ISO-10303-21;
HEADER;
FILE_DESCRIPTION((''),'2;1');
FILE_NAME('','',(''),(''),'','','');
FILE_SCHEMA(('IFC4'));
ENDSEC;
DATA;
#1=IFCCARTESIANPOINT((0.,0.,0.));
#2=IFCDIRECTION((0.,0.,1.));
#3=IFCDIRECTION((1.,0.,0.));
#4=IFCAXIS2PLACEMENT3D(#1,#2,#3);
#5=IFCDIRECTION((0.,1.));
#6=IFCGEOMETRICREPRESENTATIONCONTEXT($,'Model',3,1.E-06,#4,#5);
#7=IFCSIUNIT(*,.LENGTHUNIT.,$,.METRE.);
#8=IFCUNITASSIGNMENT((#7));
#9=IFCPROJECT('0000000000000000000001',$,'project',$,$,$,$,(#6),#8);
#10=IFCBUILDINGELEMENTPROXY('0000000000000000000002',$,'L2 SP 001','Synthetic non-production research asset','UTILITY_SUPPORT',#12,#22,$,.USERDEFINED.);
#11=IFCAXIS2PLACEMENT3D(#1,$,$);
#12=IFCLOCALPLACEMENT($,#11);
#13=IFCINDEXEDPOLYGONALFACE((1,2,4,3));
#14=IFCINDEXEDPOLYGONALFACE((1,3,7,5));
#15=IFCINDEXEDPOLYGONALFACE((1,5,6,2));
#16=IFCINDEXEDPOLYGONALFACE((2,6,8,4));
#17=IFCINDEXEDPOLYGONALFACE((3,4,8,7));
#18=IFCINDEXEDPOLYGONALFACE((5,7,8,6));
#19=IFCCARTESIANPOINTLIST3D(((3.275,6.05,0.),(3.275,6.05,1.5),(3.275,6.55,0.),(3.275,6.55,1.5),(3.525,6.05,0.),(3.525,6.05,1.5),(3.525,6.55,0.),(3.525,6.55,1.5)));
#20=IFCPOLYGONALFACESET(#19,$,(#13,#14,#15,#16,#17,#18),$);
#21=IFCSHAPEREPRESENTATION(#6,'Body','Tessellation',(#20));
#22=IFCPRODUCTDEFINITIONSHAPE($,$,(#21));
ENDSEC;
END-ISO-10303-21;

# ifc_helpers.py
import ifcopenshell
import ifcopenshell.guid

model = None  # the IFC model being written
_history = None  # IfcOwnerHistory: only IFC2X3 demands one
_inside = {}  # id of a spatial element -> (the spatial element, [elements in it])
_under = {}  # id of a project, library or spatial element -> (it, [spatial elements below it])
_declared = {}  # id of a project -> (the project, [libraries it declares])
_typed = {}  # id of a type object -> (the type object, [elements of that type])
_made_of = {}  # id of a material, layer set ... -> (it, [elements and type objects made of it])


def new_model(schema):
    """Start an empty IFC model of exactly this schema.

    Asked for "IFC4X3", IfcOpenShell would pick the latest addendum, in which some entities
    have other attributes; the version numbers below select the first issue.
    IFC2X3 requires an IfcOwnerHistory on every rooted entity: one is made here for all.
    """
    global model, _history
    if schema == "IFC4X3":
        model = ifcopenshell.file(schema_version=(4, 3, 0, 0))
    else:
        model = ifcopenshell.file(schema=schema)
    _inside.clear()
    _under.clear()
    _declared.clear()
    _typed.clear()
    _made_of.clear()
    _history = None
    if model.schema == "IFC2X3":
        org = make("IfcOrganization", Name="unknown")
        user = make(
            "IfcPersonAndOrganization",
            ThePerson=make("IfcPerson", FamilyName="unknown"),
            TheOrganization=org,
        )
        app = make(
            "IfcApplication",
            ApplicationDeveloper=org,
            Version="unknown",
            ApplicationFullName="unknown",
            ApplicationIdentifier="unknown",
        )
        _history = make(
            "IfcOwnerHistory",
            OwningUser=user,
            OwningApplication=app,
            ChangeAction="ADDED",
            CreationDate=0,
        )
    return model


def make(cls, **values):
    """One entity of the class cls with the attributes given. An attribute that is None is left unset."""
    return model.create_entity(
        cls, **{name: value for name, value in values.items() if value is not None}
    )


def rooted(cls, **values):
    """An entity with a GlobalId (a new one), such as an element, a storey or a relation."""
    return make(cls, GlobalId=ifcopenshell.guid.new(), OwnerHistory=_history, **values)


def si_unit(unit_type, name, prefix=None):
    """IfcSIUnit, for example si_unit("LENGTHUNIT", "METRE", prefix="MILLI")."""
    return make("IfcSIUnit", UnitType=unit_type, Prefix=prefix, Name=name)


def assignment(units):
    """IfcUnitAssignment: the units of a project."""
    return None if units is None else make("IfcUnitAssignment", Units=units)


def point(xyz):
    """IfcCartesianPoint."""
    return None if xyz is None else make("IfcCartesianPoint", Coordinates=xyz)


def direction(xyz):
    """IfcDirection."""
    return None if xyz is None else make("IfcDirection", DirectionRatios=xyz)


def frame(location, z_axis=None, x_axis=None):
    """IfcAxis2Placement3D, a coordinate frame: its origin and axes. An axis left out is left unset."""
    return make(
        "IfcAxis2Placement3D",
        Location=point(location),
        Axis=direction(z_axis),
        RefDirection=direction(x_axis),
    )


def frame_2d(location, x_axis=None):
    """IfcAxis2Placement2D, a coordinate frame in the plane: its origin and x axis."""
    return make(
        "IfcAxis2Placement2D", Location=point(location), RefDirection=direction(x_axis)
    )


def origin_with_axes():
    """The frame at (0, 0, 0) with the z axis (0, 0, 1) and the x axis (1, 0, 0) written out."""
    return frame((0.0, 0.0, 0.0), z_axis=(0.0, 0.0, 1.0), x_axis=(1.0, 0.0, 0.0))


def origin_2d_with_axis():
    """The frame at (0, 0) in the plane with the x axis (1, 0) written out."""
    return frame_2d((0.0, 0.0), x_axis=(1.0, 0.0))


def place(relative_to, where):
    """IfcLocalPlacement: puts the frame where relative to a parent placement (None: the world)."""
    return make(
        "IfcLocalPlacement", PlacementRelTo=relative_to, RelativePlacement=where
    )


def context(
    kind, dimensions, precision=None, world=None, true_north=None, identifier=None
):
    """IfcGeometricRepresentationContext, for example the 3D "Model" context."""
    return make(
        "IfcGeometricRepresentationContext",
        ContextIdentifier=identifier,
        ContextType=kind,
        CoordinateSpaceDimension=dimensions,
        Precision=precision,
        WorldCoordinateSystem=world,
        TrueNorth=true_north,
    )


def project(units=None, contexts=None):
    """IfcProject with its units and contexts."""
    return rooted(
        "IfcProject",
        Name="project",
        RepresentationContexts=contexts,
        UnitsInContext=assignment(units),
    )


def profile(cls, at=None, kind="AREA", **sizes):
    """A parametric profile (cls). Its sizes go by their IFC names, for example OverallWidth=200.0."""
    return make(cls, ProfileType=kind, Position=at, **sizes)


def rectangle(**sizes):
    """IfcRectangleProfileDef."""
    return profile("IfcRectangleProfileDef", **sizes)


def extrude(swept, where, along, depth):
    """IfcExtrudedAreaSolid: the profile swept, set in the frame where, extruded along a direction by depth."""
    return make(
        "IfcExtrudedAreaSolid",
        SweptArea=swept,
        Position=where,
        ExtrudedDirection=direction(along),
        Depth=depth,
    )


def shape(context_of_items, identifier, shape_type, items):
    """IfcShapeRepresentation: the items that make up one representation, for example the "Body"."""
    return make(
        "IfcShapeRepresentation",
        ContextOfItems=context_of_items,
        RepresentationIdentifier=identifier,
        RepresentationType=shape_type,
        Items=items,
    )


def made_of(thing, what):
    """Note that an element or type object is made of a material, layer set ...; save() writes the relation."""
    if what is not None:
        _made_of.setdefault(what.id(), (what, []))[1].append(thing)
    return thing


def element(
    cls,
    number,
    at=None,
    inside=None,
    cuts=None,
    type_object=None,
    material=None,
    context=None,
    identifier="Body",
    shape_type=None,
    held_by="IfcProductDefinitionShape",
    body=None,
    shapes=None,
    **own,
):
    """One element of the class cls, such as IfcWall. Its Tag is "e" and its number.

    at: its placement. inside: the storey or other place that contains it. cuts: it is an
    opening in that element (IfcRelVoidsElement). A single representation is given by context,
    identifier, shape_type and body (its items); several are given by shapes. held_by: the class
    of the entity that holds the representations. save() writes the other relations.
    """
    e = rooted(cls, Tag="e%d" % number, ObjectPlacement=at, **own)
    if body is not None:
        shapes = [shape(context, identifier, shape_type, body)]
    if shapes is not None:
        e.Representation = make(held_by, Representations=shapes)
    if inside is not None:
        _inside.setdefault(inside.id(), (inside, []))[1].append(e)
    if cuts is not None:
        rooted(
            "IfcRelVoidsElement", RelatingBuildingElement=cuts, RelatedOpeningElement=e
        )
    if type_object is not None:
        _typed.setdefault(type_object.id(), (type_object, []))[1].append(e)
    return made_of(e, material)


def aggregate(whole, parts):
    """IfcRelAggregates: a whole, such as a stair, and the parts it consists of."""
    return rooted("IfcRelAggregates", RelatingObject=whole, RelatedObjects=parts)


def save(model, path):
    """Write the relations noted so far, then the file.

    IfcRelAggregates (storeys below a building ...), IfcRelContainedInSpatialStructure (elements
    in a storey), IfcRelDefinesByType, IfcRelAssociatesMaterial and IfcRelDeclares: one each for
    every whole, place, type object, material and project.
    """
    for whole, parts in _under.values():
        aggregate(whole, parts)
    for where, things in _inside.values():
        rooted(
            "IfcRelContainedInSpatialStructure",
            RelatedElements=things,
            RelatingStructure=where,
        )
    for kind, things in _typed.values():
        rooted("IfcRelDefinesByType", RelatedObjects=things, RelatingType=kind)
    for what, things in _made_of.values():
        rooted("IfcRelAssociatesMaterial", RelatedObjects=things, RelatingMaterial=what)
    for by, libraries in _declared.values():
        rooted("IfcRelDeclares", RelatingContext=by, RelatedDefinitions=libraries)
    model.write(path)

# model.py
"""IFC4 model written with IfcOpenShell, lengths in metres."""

from ifc_helpers import new_model, si_unit, direction, frame, origin_with_axes, origin_2d_with_axis, place, context, project, rectangle, extrude, element, save


model = new_model("IFC4")

# Units and contexts
model_context = context("Model", 3, precision=1e-06, world=origin_with_axes(), true_north=direction((0.0, 1.0)))
ifc_project = project(units=[si_unit("LENGTHUNIT", "METRE")], contexts=[model_context])

# Building element proxy
proxy_placement = place(None, frame((3.4, 6.3, 0.0), z_axis=(0.0, 0.0, 1.0), x_axis=(1.0, 0.0, 0.0)))
element("IfcBuildingElementProxy", 1, at=proxy_placement, Name="L2 SP 001", Description="Synthetic non-production research asset", ObjectType="UTILITY_SUPPORT", PredefinedType="USERDEFINED", context=model_context, shape_type="SweptSolid", body=[
    extrude(rectangle(XDim=0.25, YDim=0.5, at=origin_2d_with_axis()), origin_with_axes(), (0.0, 0.0, 1.0), 1.5),
])

save(model, "model.ifc")
